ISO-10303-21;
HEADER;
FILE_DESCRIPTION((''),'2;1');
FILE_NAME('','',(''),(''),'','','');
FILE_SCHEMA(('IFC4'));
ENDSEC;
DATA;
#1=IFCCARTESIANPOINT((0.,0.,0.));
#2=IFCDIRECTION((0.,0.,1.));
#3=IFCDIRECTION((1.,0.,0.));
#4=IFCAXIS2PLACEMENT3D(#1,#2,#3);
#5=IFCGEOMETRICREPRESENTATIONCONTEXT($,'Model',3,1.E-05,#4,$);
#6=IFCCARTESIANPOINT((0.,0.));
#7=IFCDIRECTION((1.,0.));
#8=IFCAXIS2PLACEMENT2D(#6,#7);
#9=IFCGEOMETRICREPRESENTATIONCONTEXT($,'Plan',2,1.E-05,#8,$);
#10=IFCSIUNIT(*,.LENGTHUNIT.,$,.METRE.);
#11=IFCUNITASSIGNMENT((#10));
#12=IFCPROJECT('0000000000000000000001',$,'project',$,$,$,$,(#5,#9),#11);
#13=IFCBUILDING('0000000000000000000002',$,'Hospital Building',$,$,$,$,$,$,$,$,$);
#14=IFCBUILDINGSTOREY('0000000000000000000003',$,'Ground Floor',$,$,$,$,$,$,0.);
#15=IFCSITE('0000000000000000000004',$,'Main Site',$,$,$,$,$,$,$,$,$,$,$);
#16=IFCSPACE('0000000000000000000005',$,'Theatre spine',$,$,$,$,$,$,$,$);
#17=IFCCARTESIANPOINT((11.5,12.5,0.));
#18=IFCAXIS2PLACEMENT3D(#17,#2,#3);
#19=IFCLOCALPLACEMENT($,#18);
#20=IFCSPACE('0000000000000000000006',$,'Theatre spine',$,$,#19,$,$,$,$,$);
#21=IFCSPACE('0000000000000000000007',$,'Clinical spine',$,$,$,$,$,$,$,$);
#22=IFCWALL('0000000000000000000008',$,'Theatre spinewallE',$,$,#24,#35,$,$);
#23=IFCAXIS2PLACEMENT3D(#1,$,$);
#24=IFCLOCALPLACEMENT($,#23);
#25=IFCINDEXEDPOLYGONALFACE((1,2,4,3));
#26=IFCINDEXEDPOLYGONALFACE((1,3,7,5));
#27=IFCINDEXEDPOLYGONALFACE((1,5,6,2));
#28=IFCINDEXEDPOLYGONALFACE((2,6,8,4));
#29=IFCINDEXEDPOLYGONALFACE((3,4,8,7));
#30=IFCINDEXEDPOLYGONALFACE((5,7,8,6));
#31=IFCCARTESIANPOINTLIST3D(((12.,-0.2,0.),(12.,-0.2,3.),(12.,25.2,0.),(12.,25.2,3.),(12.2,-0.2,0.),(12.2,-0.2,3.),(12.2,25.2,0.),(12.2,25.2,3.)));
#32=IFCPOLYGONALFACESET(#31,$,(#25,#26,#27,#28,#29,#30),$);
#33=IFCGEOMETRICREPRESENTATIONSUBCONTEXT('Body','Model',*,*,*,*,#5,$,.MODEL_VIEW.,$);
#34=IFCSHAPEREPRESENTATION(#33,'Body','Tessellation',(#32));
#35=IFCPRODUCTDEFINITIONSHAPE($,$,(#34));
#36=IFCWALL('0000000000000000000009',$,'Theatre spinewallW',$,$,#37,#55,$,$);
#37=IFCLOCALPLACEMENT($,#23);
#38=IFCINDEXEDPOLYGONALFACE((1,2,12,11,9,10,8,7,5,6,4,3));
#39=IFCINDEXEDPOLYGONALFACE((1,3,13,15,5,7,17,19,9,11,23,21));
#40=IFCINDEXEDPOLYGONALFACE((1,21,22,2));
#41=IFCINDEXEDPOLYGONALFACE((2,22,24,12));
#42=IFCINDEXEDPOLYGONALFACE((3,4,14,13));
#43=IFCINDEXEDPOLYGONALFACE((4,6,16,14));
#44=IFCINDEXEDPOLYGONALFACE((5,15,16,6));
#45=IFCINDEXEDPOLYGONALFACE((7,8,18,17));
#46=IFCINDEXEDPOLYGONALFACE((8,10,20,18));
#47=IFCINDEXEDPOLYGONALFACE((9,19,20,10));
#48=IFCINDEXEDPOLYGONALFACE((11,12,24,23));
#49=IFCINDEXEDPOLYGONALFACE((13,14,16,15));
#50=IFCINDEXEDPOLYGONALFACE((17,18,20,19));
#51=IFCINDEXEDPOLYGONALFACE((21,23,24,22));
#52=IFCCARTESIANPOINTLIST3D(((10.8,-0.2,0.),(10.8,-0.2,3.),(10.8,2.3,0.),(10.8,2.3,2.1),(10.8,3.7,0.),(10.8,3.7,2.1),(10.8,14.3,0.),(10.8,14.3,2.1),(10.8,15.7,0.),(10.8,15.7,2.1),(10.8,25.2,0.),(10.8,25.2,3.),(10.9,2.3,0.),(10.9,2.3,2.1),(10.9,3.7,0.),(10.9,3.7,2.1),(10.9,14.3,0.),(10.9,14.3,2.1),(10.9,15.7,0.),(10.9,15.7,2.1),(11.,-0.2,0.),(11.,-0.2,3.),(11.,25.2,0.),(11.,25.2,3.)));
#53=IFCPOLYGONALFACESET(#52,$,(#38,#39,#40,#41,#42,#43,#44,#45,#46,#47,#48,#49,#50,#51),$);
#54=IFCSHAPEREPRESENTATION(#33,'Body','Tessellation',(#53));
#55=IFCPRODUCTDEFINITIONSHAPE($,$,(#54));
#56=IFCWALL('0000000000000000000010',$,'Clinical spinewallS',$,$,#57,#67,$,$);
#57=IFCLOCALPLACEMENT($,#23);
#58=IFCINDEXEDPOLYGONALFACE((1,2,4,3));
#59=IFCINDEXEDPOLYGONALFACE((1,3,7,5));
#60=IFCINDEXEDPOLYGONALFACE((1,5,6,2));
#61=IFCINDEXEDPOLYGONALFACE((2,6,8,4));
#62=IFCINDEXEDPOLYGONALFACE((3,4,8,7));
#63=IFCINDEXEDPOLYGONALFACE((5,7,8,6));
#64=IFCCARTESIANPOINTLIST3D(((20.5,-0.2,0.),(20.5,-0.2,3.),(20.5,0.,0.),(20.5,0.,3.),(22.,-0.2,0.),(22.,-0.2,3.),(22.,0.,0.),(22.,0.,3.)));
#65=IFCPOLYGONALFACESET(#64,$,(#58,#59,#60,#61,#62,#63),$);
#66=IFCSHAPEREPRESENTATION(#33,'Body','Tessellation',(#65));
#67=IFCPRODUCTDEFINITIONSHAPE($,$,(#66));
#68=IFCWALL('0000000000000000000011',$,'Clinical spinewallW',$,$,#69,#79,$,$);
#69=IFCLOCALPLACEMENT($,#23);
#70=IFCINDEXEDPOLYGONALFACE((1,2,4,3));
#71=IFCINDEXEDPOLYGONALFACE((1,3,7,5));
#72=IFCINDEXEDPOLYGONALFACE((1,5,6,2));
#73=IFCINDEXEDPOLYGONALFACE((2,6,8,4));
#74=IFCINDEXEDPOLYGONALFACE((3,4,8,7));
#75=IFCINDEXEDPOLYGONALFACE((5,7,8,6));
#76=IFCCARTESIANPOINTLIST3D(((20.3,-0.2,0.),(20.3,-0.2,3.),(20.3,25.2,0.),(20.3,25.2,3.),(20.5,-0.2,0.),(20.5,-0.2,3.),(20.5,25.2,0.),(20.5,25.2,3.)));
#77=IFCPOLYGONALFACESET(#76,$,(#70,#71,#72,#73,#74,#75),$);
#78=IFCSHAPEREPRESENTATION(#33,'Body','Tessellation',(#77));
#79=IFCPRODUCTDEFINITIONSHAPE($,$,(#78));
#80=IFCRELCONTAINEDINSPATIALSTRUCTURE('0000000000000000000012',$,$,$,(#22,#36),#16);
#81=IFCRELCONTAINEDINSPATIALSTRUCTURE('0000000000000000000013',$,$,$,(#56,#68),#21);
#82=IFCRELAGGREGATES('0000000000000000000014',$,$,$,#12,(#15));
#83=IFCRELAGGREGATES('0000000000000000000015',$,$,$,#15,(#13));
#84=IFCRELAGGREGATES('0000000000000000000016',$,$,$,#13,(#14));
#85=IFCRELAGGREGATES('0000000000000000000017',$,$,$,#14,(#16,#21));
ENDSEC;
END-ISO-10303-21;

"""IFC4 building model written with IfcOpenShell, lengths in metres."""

from ifc_helpers import new_model, si_unit, frame, origin_with_axes, origin_2d_with_axis, place, context, subcontext, project, spatial, indexed_curve, outline, extrude, element, save


model = new_model("IFC4")

# Units and contexts
model_context = context("Model", 3, precision=1e-05, world=origin_with_axes())
plan_context = context("Plan", 2, precision=1e-05, world=origin_2d_with_axis())
body_context = subcontext(model_context, "Body", "Model", "MODEL_VIEW")
ifc_project = project(units=[si_unit("LENGTHUNIT", "METRE")], contexts=[model_context, plan_context])

# Site, building, storey
site = spatial("IfcSite", under=ifc_project, Name="Main Site")
building = spatial("IfcBuilding", under=site, Name="Hospital Building")
storey = spatial("IfcBuildingStorey", under=building, Name="Ground Floor", Elevation=0.0)

# Shared definitions
space_1 = spatial("IfcSpace", under=storey, Name="Theatre spine")

# Wall
wall_1_placement = place(None, frame((12.2, -0.2, 0.0), z_axis=(0.0, 0.0, 1.0), x_axis=(0.0, 1.0, 0.0)))
element("IfcWall", 1, at=wall_1_placement, inside=space_1, Name="Theatre spinewallE", context=body_context, shape_type="SweptSolid", body=[
    extrude(outline(indexed_curve([(0.0, 0.0), (0.0, 0.2), (25.4, 0.2), (25.4, 0.0), (0.0, 0.0)], self_intersect=False)), origin_with_axes(), (0.0, 0.0, 1.0), 3.0),
])

# Wall
wall_2_placement = place(None, frame((11.0, -0.2, 0.0), z_axis=(0.0, 0.0, 1.0), x_axis=(0.0, 1.0, 0.0)))
wall_2 = element("IfcWall", 2, at=wall_2_placement, inside=space_1, Name="Theatre spinewallW", context=body_context, shape_type="SweptSolid", body=[
    extrude(outline(indexed_curve([(0.0, 0.0), (0.0, 0.2), (25.4, 0.2), (25.4, 0.0), (0.0, 0.0)], self_intersect=False)), origin_with_axes(), (0.0, 0.0, 1.0), 3.0),
])

# Shared definitions
space_2_placement = place(None, frame((11.5, 12.5, 0.0), z_axis=(0.0, 0.0, 1.0), x_axis=(1.0, 0.0, 0.0)))
space_2 = spatial("IfcSpace", at=space_2_placement, Name="Theatre spine")

# Openings
opening_1_placement = place(wall_2_placement, frame((14.5, 0.1, 0.0), z_axis=(0.0, 0.0, 1.0), x_axis=(1.0, 0.0, 0.0)))
element("IfcOpeningElement", 3, at=opening_1_placement, inside=space_2, cuts=wall_2, context=body_context, shape_type="SweptSolid", body=[
    extrude(outline(indexed_curve([(0.0, 0.0), (0.0, 0.4), (1.4, 0.4), (1.4, 0.0), (0.0, 0.0)], self_intersect=False)), origin_with_axes(), (0.0, 0.0, 1.0), 2.1),
])
opening_2_placement = place(wall_2_placement, frame((2.5, 0.1, 0.0), z_axis=(0.0, 0.0, 1.0), x_axis=(1.0, 0.0, 0.0)))
element("IfcOpeningElement", 4, at=opening_2_placement, inside=space_2, cuts=wall_2, context=body_context, shape_type="SweptSolid", body=[
    extrude(outline(indexed_curve([(0.0, 0.0), (0.0, 0.4), (1.4, 0.4), (1.4, 0.0), (0.0, 0.0)], self_intersect=False)), origin_with_axes(), (0.0, 0.0, 1.0), 2.1),
])

# Shared definitions
space_3 = spatial("IfcSpace", under=storey, Name="Clinical spine")

# Walls
wall_3_placement = place(None, frame((20.5, -0.2, 0.0), z_axis=(0.0, 0.0, 1.0), x_axis=(1.0, 0.0, 0.0)))
element("IfcWall", 5, at=wall_3_placement, inside=space_3, Name="Clinical spinewallS", context=body_context, shape_type="SweptSolid", body=[
    extrude(outline(indexed_curve([(0.0, 0.0), (0.0, 0.2), (1.5, 0.2), (1.5, 0.0), (0.0, 0.0)], self_intersect=False)), origin_with_axes(), (0.0, 0.0, 1.0), 3.0),
])
wall_4_placement = place(None, frame((20.5, -0.2, 0.0), z_axis=(0.0, 0.0, 1.0), x_axis=(0.0, 1.0, 0.0)))
element("IfcWall", 6, at=wall_4_placement, inside=space_3, Name="Clinical spinewallW", context=body_context, shape_type="SweptSolid", body=[
    extrude(outline(indexed_curve([(0.0, 0.0), (0.0, 0.2), (25.4, 0.2), (25.4, 0.0), (0.0, 0.0)], self_intersect=False)), origin_with_axes(), (0.0, 0.0, 1.0), 3.0),
])

save(model, "model.ifc")
